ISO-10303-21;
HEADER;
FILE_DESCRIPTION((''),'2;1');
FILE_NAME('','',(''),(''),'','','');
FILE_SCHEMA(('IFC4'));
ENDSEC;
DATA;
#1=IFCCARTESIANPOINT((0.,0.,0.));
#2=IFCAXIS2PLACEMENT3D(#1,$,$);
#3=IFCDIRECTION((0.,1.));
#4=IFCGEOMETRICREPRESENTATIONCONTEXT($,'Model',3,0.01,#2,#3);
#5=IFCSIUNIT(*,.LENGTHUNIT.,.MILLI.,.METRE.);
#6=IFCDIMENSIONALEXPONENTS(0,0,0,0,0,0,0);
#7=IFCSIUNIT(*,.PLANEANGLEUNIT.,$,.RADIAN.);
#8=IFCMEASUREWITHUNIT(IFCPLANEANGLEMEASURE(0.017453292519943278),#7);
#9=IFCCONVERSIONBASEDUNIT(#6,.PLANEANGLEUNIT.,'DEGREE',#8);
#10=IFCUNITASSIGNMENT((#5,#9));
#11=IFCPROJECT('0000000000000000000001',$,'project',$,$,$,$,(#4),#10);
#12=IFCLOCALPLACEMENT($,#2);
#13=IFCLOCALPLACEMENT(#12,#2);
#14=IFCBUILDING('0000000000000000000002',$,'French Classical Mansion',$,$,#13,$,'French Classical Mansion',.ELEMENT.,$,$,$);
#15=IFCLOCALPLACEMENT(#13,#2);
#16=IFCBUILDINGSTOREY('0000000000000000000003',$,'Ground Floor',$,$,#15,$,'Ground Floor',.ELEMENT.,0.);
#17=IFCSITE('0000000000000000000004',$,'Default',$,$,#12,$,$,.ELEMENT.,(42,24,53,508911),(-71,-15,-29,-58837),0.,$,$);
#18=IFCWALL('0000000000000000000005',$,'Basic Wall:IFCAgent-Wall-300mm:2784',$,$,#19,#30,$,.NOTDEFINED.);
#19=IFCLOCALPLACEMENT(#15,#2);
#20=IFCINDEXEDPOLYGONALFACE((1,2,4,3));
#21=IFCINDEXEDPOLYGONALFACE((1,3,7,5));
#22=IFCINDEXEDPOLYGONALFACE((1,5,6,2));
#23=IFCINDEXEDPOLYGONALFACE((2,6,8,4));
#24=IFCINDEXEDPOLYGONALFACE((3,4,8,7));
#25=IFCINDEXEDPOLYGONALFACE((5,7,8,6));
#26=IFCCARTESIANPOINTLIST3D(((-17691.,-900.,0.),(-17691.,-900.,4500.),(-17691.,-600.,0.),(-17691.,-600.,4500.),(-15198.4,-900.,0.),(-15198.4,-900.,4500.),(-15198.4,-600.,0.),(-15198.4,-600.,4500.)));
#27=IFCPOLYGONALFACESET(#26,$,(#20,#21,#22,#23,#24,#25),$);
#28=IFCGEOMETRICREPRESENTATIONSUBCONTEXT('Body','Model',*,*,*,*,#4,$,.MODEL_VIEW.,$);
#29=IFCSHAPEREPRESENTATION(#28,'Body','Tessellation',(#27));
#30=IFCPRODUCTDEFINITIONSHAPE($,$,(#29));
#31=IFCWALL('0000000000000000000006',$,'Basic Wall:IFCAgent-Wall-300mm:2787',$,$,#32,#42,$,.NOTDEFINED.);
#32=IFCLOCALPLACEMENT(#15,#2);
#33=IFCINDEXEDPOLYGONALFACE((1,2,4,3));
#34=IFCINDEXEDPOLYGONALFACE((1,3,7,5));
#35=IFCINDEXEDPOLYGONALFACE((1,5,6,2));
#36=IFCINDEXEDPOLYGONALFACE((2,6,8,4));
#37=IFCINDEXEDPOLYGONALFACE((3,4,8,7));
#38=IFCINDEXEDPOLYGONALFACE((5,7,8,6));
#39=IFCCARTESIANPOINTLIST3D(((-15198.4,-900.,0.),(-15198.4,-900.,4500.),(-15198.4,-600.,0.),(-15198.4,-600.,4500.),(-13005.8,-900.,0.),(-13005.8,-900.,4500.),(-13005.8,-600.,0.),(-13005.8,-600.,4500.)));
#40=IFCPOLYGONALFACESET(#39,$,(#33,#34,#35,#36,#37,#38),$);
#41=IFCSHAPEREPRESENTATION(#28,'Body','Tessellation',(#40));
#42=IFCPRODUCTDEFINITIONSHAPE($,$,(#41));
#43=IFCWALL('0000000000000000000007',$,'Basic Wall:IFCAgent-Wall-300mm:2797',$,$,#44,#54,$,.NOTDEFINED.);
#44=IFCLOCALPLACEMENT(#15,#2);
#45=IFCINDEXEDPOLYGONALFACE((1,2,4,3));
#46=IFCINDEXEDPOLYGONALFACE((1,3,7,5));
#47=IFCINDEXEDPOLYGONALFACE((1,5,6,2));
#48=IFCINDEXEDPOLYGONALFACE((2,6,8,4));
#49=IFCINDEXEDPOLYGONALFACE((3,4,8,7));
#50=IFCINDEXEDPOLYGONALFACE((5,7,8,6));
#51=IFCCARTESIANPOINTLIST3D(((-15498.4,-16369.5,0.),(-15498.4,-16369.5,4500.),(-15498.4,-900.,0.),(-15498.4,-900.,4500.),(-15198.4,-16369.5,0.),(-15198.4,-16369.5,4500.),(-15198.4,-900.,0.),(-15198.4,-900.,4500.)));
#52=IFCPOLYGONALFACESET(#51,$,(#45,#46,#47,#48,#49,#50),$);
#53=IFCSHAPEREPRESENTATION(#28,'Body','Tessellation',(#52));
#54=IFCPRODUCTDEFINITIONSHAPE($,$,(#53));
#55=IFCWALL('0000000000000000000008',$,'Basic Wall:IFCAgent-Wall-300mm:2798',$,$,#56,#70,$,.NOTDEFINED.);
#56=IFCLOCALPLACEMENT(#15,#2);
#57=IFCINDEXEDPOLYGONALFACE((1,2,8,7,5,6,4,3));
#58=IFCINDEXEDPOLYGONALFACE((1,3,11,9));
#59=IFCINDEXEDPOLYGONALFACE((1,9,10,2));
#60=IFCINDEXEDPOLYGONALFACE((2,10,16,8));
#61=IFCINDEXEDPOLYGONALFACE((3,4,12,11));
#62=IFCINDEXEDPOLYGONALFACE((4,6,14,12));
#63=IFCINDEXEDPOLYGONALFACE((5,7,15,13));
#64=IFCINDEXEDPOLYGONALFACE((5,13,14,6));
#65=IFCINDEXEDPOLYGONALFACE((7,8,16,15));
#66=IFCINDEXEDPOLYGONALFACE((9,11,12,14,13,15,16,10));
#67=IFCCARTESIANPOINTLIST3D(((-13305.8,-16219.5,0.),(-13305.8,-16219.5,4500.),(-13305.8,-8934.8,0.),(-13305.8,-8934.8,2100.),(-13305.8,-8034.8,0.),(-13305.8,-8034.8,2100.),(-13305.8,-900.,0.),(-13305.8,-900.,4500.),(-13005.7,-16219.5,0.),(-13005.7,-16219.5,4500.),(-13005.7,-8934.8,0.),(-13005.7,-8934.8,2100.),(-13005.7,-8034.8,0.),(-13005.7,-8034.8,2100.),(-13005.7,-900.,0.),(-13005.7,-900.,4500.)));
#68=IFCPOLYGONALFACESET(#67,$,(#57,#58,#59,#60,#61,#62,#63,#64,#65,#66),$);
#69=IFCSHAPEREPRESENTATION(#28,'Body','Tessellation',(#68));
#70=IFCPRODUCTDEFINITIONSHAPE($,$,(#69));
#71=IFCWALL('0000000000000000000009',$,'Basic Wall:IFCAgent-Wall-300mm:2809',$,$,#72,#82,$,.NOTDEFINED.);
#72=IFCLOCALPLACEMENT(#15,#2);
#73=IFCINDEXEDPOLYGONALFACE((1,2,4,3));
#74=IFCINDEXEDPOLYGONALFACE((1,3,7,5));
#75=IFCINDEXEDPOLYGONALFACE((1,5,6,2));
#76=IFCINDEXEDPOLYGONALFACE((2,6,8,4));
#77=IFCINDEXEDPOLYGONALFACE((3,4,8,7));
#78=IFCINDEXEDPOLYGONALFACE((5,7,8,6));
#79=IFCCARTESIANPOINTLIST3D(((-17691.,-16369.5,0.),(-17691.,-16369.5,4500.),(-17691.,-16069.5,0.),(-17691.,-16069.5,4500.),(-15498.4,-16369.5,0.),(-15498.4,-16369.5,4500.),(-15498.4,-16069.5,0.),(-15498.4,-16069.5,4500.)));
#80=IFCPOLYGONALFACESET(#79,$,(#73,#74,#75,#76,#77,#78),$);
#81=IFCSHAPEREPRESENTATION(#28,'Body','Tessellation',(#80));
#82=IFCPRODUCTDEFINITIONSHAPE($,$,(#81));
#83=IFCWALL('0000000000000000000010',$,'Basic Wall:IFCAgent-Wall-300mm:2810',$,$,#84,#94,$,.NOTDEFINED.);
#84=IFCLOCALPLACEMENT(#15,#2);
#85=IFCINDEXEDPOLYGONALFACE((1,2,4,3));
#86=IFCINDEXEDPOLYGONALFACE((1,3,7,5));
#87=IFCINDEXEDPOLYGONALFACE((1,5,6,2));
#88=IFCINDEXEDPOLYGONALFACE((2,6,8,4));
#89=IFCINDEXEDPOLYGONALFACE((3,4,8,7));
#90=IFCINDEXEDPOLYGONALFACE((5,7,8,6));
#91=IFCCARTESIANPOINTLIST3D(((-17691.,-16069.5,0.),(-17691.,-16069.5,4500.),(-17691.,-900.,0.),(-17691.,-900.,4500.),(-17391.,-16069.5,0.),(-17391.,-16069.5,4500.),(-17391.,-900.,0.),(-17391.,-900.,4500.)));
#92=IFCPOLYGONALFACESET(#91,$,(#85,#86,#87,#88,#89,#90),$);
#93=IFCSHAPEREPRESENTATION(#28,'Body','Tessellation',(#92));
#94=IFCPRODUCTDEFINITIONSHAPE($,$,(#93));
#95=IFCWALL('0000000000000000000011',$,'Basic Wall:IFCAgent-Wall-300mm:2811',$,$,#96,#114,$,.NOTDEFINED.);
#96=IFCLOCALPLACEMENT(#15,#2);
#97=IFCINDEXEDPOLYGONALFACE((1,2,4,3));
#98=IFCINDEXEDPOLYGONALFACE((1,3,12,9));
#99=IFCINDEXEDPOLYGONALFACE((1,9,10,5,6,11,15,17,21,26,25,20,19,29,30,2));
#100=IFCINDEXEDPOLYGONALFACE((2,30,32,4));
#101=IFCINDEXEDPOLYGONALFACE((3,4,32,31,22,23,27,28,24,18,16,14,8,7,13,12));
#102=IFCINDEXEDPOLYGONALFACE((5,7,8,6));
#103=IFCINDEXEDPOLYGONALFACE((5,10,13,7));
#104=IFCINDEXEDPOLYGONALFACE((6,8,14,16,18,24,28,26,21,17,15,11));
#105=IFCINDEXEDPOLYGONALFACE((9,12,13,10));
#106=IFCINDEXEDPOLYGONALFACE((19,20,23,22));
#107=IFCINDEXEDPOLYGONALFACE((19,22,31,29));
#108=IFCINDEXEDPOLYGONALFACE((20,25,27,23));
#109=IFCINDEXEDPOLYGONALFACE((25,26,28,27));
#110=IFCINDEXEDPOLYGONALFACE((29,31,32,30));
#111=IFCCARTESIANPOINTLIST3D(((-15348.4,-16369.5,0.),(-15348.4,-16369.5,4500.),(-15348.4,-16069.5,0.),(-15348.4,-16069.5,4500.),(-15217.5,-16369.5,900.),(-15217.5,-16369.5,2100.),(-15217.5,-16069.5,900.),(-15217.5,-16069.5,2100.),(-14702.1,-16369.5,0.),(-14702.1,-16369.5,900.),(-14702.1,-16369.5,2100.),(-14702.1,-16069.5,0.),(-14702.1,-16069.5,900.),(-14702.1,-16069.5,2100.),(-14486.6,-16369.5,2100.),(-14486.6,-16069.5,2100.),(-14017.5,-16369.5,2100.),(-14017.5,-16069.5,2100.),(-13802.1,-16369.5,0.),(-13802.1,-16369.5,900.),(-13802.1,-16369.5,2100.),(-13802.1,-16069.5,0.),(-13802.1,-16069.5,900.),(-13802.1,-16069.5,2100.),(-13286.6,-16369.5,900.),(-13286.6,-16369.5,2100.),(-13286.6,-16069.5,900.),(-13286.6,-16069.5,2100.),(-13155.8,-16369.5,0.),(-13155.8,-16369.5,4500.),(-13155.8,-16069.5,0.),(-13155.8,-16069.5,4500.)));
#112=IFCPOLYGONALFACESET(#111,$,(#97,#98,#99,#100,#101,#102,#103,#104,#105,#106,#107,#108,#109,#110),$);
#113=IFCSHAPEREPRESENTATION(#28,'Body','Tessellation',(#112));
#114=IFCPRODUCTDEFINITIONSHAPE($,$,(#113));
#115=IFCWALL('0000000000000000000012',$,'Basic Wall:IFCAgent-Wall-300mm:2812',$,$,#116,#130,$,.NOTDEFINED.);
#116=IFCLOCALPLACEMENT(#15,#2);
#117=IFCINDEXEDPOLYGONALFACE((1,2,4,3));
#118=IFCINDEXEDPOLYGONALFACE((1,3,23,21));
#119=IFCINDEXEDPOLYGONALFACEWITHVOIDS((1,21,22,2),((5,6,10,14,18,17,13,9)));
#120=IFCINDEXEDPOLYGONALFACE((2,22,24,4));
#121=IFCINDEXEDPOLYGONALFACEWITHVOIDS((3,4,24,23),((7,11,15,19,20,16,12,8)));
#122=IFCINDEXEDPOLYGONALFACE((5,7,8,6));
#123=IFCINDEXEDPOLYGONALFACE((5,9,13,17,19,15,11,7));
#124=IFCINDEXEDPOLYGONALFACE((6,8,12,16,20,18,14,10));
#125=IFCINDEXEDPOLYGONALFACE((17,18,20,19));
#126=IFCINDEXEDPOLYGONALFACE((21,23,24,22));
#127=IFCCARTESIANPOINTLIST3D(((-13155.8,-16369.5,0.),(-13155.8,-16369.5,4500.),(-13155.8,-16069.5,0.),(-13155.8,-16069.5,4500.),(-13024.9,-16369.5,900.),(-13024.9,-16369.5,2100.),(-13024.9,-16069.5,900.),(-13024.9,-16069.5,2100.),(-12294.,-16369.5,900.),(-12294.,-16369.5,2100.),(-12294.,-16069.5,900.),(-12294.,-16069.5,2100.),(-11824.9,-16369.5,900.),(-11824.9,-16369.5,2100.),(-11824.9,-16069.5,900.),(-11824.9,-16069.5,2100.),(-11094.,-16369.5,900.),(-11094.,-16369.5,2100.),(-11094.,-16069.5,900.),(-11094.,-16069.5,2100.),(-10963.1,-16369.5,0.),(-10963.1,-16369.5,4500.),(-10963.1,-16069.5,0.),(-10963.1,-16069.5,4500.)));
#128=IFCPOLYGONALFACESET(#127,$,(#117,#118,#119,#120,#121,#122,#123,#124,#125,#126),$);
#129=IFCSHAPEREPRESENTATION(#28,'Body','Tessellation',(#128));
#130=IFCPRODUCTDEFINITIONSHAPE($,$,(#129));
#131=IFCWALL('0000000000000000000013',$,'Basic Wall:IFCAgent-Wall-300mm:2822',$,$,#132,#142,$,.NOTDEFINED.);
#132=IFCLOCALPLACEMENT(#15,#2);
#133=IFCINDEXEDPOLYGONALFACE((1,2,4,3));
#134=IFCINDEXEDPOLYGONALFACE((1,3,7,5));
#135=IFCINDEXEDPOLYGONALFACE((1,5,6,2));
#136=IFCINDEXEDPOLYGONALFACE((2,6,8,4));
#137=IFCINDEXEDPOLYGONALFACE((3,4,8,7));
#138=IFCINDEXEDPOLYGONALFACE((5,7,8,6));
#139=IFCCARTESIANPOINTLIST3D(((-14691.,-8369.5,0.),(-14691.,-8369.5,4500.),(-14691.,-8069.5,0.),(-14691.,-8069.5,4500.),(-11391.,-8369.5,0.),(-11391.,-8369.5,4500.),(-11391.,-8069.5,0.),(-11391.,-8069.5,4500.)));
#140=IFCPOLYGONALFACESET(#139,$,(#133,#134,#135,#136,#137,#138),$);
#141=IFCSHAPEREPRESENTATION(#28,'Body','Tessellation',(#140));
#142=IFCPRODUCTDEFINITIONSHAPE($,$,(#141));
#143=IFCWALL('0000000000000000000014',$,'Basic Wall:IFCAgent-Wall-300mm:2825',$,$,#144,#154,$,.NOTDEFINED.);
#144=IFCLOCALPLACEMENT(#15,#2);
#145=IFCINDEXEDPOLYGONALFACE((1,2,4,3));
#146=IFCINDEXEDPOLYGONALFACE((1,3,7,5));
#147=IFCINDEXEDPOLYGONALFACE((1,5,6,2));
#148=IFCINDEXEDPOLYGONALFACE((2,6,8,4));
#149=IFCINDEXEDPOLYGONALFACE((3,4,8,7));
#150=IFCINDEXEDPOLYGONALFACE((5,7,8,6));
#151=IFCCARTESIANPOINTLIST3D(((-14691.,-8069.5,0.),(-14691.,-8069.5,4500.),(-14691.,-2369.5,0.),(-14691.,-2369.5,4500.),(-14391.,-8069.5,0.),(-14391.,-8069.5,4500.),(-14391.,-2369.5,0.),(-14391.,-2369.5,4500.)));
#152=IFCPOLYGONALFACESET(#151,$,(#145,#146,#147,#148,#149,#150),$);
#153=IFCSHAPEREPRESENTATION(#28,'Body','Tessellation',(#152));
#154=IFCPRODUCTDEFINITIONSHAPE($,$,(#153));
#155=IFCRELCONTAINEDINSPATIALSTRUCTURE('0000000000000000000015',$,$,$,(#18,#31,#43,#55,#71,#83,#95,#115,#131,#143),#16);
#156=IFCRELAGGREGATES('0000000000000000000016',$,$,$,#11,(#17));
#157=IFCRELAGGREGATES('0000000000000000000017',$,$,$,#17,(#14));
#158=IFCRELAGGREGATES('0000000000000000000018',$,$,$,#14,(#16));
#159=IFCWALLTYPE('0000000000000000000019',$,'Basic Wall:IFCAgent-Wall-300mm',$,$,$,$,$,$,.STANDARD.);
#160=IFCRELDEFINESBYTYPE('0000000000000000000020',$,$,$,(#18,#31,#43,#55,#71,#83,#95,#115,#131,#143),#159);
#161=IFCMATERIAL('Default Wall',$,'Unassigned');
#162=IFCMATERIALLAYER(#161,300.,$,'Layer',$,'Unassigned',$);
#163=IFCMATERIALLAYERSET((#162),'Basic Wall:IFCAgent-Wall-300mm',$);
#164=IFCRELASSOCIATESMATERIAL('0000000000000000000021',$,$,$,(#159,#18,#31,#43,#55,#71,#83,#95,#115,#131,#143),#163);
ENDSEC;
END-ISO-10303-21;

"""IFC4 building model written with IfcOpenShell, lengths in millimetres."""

from ifc_helpers import new_model, entity, si_unit, converted_unit, direction, frame, frame_2d, origin, place, context, subcontext, project, spatial, rectangle, extrude, material, layer, layer_set, layer_usage, type_object, element, save


model = new_model("IFC4")

# Units and contexts
model_context = context("Model", 3, precision=0.01, world=origin(), true_north=direction((0.0, 1.0)))
body_context = subcontext(model_context, "Body", "Model", "MODEL_VIEW")
ifc_project = project(units=[si_unit("LENGTHUNIT", "METRE", prefix="MILLI"), converted_unit("PLANEANGLEUNIT", "DEGREE", entity("IfcPlaneAngleMeasure", 0.017453292519943278), si_unit("PLANEANGLEUNIT", "RADIAN"), dimensions=[0, 0, 0, 0, 0, 0, 0])], contexts=[model_context])

# Site, building, storey
site_placement = place(None, origin())
site = spatial("IfcSite", under=ifc_project, at=site_placement, Name="Default", CompositionType="ELEMENT", RefLatitude=(42, 24, 53, 508911), RefLongitude=(-71, -15, -29, -58837), RefElevation=0.0)
building_placement = place(site_placement, origin())
building = spatial("IfcBuilding", under=site, at=building_placement, Name="French Classical Mansion", LongName="French Classical Mansion", CompositionType="ELEMENT")
storey_placement = place(building_placement, origin())
storey = spatial("IfcBuildingStorey", under=building, at=storey_placement, Name="Ground Floor", LongName="Ground Floor", CompositionType="ELEMENT", Elevation=0.0)

# Walls
ifc_material = material(Name="Default Wall", Category="Unassigned")
ifc_layer = layer(ifc_material, 300.0, Name="Layer", Category="Unassigned")
ifc_layer_set = layer_set([ifc_layer], Name="Basic Wall:IFCAgent-Wall-300mm")
ifc_layer_usage_1 = layer_usage(ifc_layer_set, "AXIS2", "NEGATIVE", 150.0)
wall_type = type_object("IfcWallType", Name="Basic Wall:IFCAgent-Wall-300mm", PredefinedType="STANDARD", material=ifc_layer_set)
wall_1_placement = place(storey_placement, frame((-17691.0, -750.0, 0.0)))
element("IfcWall", 1, at=wall_1_placement, inside=storey, type_object=wall_type, material=ifc_layer_usage_1, Name="Basic Wall:IFCAgent-Wall-300mm:2784", PredefinedType="NOTDEFINED", context=body_context, shape_type="SweptSolid", body=[
    extrude(rectangle(XDim=2492.6, YDim=300.0, at=frame_2d((1246.3, 0.0), x_axis=(-1.0, 0.0))), origin(), (0.0, 0.0, 1.0), 4500.0),
])
ifc_layer_usage_2 = layer_usage(ifc_layer_set, "AXIS2", "NEGATIVE", 150.0)
wall_2_placement = place(storey_placement, frame((-15198.4, -750.0, 0.0)))
element("IfcWall", 2, at=wall_2_placement, inside=storey, type_object=wall_type, material=ifc_layer_usage_2, Name="Basic Wall:IFCAgent-Wall-300mm:2787", PredefinedType="NOTDEFINED", context=body_context, shape_type="SweptSolid", body=[
    extrude(rectangle(XDim=2192.6, YDim=300.0, at=frame_2d((1096.3, 0.0), x_axis=(-1.0, 0.0))), origin(), (0.0, 0.0, 1.0), 4500.0),
])
ifc_layer_usage_3 = layer_usage(ifc_layer_set, "AXIS2", "NEGATIVE", 150.0)
wall_3_placement = place(storey_placement, frame((-15348.4, -16369.5, 0.0), z_axis=(0.0, 0.0, 1.0), x_axis=(0.0, 1.0, 0.0)))
element("IfcWall", 3, at=wall_3_placement, inside=storey, type_object=wall_type, material=ifc_layer_usage_3, Name="Basic Wall:IFCAgent-Wall-300mm:2797", PredefinedType="NOTDEFINED", context=body_context, shape_type="SweptSolid", body=[
    extrude(rectangle(XDim=15469.5, YDim=300.0, at=frame_2d((7734.8, 0.0), x_axis=(-1.0, 0.0))), origin(), (0.0, 0.0, 1.0), 4500.0),
])

# Wall, opening
ifc_layer_usage_4 = layer_usage(ifc_layer_set, "AXIS2", "NEGATIVE", 150.0)
wall_4_placement = place(storey_placement, frame((-13155.8, -16219.5, 0.0), z_axis=(0.0, 0.0, 1.0), x_axis=(0.0, 1.0, 0.0)))
wall_4 = element("IfcWall", 4, at=wall_4_placement, inside=storey, type_object=wall_type, material=ifc_layer_usage_4, Name="Basic Wall:IFCAgent-Wall-300mm:2798", PredefinedType="NOTDEFINED", context=body_context, shape_type="SweptSolid", body=[
    extrude(rectangle(XDim=15319.5, YDim=300.0, at=frame_2d((7659.8, 0.0), x_axis=(-1.0, 0.0))), origin(), (0.0, 0.0, 1.0), 4500.0),
])
opening_1_placement = place(wall_4_placement, origin())
element("IfcOpeningElement", 5, at=opening_1_placement, cuts=wall_4, PredefinedType="OPENING", context=body_context, shape_type="SweptSolid", body=[
    extrude(rectangle(XDim=2100.0, YDim=900.0, at=frame_2d((0.0, 0.0), x_axis=(1.0, 0.0))), frame((7734.8, -150.0, 1050.0), z_axis=(0.0, 1.0, 0.0), x_axis=(0.0, 0.0, -1.0)), (0.0, 0.0, 1.0), 300.0),
])

# Walls
ifc_layer_usage_5 = layer_usage(ifc_layer_set, "AXIS2", "NEGATIVE", 150.0)
wall_5_placement = place(storey_placement, frame((-17691.0, -16219.5, 0.0)))
element("IfcWall", 6, at=wall_5_placement, inside=storey, type_object=wall_type, material=ifc_layer_usage_5, Name="Basic Wall:IFCAgent-Wall-300mm:2809", PredefinedType="NOTDEFINED", context=body_context, shape_type="SweptSolid", body=[
    extrude(rectangle(XDim=2192.6, YDim=300.0, at=frame_2d((1096.3, 0.0), x_axis=(-1.0, 0.0))), origin(), (0.0, 0.0, 1.0), 4500.0),
])
ifc_layer_usage_6 = layer_usage(ifc_layer_set, "AXIS2", "NEGATIVE", 150.0)
wall_6_placement = place(storey_placement, frame((-17541.0, -16069.5, 0.0), z_axis=(0.0, 0.0, 1.0), x_axis=(0.0, 1.0, 0.0)))
element("IfcWall", 7, at=wall_6_placement, inside=storey, type_object=wall_type, material=ifc_layer_usage_6, Name="Basic Wall:IFCAgent-Wall-300mm:2810", PredefinedType="NOTDEFINED", context=body_context, shape_type="SweptSolid", body=[
    extrude(rectangle(XDim=15169.5, YDim=300.0, at=frame_2d((7584.8, 0.0), x_axis=(-1.0, 0.0))), origin(), (0.0, 0.0, 1.0), 4500.0),
])

# Walls, openings
ifc_layer_usage_7 = layer_usage(ifc_layer_set, "AXIS2", "NEGATIVE", 150.0)
wall_7_placement = place(storey_placement, frame((-15348.4, -16219.5, 0.0)))
wall_7 = element("IfcWall", 8, at=wall_7_placement, inside=storey, type_object=wall_type, material=ifc_layer_usage_7, Name="Basic Wall:IFCAgent-Wall-300mm:2811", PredefinedType="NOTDEFINED", context=body_context, shape_type="SweptSolid", body=[
    extrude(rectangle(XDim=2192.6, YDim=300.0, at=frame_2d((1096.3, 0.0), x_axis=(-1.0, 0.0))), origin(), (0.0, 0.0, 1.0), 4500.0),
])
opening_2_placement = place(wall_7_placement, origin())
element("IfcOpeningElement", 9, at=opening_2_placement, cuts=wall_7, PredefinedType="OPENING", context=body_context, shape_type="SweptSolid", body=[
    extrude(rectangle(XDim=2100.0, YDim=900.0, at=frame_2d((0.0, 0.0), x_axis=(1.0, 0.0))), frame((1096.3, -150.0, 1050.0), z_axis=(0.0, 1.0, 0.0), x_axis=(0.0, 0.0, -1.0)), (0.0, 0.0, 1.0), 300.0),
])
opening_3_placement = place(wall_7_placement, origin())
element("IfcOpeningElement", 10, at=opening_3_placement, cuts=wall_7, PredefinedType="OPENING", context=body_context, shape_type="SweptSolid", body=[
    extrude(rectangle(XDim=1200.0, YDim=1200.0, at=frame_2d((0.0, 0.0), x_axis=(1.0, 0.0))), frame((730.9, -150.0, 1500.0), z_axis=(0.0, 1.0, 0.0), x_axis=(0.0, 0.0, -1.0)), (0.0, 0.0, 1.0), 300.0),
])
opening_4_placement = place(wall_7_placement, origin())
element("IfcOpeningElement", 11, at=opening_4_placement, cuts=wall_7, PredefinedType="OPENING", context=body_context, shape_type="SweptSolid", body=[
    extrude(rectangle(XDim=1200.0, YDim=1200.0, at=frame_2d((0.0, 0.0), x_axis=(1.0, 0.0))), frame((1461.7, -150.0, 1500.0), z_axis=(0.0, 1.0, 0.0), x_axis=(0.0, 0.0, -1.0)), (0.0, 0.0, 1.0), 300.0),
])
ifc_layer_usage_8 = layer_usage(ifc_layer_set, "AXIS2", "NEGATIVE", 150.0)
wall_8_placement = place(storey_placement, frame((-13155.8, -16219.5, 0.0)))
wall_8 = element("IfcWall", 12, at=wall_8_placement, inside=storey, type_object=wall_type, material=ifc_layer_usage_8, Name="Basic Wall:IFCAgent-Wall-300mm:2812", PredefinedType="NOTDEFINED", context=body_context, shape_type="SweptSolid", body=[
    extrude(rectangle(XDim=2192.6, YDim=300.0, at=frame_2d((1096.3, 0.0), x_axis=(-1.0, 0.0))), origin(), (0.0, 0.0, 1.0), 4500.0),
])
opening_5_placement = place(wall_8_placement, origin())
element("IfcOpeningElement", 13, at=opening_5_placement, cuts=wall_8, PredefinedType="OPENING", context=body_context, shape_type="SweptSolid", body=[
    extrude(rectangle(XDim=1200.0, YDim=1200.0, at=frame_2d((0.0, 0.0), x_axis=(1.0, 0.0))), frame((730.9, -150.0, 1500.0), z_axis=(0.0, 1.0, 0.0), x_axis=(0.0, 0.0, -1.0)), (0.0, 0.0, 1.0), 300.0),
])
opening_6_placement = place(wall_8_placement, origin())
element("IfcOpeningElement", 14, at=opening_6_placement, cuts=wall_8, PredefinedType="OPENING", context=body_context, shape_type="SweptSolid", body=[
    extrude(rectangle(XDim=1200.0, YDim=1200.0, at=frame_2d((0.0, 0.0), x_axis=(1.0, 0.0))), frame((1461.7, -150.0, 1500.0), z_axis=(0.0, 1.0, 0.0), x_axis=(0.0, 0.0, -1.0)), (0.0, 0.0, 1.0), 300.0),
])

# Walls
ifc_layer_usage_9 = layer_usage(ifc_layer_set, "AXIS2", "NEGATIVE", 150.0)
wall_9_placement = place(storey_placement, frame((-14691.0, -8219.5, 0.0)))
element("IfcWall", 15, at=wall_9_placement, inside=storey, type_object=wall_type, material=ifc_layer_usage_9, Name="Basic Wall:IFCAgent-Wall-300mm:2822", PredefinedType="NOTDEFINED", context=body_context, shape_type="SweptSolid", body=[
    extrude(rectangle(XDim=3300.0, YDim=300.0, at=frame_2d((1650.0, 0.0), x_axis=(-1.0, 0.0))), origin(), (0.0, 0.0, 1.0), 4500.0),
])
ifc_layer_usage_10 = layer_usage(ifc_layer_set, "AXIS2", "NEGATIVE", 150.0)
wall_10_placement = place(storey_placement, frame((-14541.0, -2369.5, 0.0), z_axis=(0.0, 0.0, 1.0), x_axis=(0.0, -1.0, 0.0)))
element("IfcWall", 16, at=wall_10_placement, inside=storey, type_object=wall_type, material=ifc_layer_usage_10, Name="Basic Wall:IFCAgent-Wall-300mm:2825", PredefinedType="NOTDEFINED", context=body_context, shape_type="SweptSolid", body=[
    extrude(rectangle(XDim=5700.0, YDim=300.0, at=frame_2d((2850.0, 0.0), x_axis=(-1.0, 0.0))), origin(), (0.0, 0.0, 1.0), 4500.0),
])

save(model, "model.ifc")
